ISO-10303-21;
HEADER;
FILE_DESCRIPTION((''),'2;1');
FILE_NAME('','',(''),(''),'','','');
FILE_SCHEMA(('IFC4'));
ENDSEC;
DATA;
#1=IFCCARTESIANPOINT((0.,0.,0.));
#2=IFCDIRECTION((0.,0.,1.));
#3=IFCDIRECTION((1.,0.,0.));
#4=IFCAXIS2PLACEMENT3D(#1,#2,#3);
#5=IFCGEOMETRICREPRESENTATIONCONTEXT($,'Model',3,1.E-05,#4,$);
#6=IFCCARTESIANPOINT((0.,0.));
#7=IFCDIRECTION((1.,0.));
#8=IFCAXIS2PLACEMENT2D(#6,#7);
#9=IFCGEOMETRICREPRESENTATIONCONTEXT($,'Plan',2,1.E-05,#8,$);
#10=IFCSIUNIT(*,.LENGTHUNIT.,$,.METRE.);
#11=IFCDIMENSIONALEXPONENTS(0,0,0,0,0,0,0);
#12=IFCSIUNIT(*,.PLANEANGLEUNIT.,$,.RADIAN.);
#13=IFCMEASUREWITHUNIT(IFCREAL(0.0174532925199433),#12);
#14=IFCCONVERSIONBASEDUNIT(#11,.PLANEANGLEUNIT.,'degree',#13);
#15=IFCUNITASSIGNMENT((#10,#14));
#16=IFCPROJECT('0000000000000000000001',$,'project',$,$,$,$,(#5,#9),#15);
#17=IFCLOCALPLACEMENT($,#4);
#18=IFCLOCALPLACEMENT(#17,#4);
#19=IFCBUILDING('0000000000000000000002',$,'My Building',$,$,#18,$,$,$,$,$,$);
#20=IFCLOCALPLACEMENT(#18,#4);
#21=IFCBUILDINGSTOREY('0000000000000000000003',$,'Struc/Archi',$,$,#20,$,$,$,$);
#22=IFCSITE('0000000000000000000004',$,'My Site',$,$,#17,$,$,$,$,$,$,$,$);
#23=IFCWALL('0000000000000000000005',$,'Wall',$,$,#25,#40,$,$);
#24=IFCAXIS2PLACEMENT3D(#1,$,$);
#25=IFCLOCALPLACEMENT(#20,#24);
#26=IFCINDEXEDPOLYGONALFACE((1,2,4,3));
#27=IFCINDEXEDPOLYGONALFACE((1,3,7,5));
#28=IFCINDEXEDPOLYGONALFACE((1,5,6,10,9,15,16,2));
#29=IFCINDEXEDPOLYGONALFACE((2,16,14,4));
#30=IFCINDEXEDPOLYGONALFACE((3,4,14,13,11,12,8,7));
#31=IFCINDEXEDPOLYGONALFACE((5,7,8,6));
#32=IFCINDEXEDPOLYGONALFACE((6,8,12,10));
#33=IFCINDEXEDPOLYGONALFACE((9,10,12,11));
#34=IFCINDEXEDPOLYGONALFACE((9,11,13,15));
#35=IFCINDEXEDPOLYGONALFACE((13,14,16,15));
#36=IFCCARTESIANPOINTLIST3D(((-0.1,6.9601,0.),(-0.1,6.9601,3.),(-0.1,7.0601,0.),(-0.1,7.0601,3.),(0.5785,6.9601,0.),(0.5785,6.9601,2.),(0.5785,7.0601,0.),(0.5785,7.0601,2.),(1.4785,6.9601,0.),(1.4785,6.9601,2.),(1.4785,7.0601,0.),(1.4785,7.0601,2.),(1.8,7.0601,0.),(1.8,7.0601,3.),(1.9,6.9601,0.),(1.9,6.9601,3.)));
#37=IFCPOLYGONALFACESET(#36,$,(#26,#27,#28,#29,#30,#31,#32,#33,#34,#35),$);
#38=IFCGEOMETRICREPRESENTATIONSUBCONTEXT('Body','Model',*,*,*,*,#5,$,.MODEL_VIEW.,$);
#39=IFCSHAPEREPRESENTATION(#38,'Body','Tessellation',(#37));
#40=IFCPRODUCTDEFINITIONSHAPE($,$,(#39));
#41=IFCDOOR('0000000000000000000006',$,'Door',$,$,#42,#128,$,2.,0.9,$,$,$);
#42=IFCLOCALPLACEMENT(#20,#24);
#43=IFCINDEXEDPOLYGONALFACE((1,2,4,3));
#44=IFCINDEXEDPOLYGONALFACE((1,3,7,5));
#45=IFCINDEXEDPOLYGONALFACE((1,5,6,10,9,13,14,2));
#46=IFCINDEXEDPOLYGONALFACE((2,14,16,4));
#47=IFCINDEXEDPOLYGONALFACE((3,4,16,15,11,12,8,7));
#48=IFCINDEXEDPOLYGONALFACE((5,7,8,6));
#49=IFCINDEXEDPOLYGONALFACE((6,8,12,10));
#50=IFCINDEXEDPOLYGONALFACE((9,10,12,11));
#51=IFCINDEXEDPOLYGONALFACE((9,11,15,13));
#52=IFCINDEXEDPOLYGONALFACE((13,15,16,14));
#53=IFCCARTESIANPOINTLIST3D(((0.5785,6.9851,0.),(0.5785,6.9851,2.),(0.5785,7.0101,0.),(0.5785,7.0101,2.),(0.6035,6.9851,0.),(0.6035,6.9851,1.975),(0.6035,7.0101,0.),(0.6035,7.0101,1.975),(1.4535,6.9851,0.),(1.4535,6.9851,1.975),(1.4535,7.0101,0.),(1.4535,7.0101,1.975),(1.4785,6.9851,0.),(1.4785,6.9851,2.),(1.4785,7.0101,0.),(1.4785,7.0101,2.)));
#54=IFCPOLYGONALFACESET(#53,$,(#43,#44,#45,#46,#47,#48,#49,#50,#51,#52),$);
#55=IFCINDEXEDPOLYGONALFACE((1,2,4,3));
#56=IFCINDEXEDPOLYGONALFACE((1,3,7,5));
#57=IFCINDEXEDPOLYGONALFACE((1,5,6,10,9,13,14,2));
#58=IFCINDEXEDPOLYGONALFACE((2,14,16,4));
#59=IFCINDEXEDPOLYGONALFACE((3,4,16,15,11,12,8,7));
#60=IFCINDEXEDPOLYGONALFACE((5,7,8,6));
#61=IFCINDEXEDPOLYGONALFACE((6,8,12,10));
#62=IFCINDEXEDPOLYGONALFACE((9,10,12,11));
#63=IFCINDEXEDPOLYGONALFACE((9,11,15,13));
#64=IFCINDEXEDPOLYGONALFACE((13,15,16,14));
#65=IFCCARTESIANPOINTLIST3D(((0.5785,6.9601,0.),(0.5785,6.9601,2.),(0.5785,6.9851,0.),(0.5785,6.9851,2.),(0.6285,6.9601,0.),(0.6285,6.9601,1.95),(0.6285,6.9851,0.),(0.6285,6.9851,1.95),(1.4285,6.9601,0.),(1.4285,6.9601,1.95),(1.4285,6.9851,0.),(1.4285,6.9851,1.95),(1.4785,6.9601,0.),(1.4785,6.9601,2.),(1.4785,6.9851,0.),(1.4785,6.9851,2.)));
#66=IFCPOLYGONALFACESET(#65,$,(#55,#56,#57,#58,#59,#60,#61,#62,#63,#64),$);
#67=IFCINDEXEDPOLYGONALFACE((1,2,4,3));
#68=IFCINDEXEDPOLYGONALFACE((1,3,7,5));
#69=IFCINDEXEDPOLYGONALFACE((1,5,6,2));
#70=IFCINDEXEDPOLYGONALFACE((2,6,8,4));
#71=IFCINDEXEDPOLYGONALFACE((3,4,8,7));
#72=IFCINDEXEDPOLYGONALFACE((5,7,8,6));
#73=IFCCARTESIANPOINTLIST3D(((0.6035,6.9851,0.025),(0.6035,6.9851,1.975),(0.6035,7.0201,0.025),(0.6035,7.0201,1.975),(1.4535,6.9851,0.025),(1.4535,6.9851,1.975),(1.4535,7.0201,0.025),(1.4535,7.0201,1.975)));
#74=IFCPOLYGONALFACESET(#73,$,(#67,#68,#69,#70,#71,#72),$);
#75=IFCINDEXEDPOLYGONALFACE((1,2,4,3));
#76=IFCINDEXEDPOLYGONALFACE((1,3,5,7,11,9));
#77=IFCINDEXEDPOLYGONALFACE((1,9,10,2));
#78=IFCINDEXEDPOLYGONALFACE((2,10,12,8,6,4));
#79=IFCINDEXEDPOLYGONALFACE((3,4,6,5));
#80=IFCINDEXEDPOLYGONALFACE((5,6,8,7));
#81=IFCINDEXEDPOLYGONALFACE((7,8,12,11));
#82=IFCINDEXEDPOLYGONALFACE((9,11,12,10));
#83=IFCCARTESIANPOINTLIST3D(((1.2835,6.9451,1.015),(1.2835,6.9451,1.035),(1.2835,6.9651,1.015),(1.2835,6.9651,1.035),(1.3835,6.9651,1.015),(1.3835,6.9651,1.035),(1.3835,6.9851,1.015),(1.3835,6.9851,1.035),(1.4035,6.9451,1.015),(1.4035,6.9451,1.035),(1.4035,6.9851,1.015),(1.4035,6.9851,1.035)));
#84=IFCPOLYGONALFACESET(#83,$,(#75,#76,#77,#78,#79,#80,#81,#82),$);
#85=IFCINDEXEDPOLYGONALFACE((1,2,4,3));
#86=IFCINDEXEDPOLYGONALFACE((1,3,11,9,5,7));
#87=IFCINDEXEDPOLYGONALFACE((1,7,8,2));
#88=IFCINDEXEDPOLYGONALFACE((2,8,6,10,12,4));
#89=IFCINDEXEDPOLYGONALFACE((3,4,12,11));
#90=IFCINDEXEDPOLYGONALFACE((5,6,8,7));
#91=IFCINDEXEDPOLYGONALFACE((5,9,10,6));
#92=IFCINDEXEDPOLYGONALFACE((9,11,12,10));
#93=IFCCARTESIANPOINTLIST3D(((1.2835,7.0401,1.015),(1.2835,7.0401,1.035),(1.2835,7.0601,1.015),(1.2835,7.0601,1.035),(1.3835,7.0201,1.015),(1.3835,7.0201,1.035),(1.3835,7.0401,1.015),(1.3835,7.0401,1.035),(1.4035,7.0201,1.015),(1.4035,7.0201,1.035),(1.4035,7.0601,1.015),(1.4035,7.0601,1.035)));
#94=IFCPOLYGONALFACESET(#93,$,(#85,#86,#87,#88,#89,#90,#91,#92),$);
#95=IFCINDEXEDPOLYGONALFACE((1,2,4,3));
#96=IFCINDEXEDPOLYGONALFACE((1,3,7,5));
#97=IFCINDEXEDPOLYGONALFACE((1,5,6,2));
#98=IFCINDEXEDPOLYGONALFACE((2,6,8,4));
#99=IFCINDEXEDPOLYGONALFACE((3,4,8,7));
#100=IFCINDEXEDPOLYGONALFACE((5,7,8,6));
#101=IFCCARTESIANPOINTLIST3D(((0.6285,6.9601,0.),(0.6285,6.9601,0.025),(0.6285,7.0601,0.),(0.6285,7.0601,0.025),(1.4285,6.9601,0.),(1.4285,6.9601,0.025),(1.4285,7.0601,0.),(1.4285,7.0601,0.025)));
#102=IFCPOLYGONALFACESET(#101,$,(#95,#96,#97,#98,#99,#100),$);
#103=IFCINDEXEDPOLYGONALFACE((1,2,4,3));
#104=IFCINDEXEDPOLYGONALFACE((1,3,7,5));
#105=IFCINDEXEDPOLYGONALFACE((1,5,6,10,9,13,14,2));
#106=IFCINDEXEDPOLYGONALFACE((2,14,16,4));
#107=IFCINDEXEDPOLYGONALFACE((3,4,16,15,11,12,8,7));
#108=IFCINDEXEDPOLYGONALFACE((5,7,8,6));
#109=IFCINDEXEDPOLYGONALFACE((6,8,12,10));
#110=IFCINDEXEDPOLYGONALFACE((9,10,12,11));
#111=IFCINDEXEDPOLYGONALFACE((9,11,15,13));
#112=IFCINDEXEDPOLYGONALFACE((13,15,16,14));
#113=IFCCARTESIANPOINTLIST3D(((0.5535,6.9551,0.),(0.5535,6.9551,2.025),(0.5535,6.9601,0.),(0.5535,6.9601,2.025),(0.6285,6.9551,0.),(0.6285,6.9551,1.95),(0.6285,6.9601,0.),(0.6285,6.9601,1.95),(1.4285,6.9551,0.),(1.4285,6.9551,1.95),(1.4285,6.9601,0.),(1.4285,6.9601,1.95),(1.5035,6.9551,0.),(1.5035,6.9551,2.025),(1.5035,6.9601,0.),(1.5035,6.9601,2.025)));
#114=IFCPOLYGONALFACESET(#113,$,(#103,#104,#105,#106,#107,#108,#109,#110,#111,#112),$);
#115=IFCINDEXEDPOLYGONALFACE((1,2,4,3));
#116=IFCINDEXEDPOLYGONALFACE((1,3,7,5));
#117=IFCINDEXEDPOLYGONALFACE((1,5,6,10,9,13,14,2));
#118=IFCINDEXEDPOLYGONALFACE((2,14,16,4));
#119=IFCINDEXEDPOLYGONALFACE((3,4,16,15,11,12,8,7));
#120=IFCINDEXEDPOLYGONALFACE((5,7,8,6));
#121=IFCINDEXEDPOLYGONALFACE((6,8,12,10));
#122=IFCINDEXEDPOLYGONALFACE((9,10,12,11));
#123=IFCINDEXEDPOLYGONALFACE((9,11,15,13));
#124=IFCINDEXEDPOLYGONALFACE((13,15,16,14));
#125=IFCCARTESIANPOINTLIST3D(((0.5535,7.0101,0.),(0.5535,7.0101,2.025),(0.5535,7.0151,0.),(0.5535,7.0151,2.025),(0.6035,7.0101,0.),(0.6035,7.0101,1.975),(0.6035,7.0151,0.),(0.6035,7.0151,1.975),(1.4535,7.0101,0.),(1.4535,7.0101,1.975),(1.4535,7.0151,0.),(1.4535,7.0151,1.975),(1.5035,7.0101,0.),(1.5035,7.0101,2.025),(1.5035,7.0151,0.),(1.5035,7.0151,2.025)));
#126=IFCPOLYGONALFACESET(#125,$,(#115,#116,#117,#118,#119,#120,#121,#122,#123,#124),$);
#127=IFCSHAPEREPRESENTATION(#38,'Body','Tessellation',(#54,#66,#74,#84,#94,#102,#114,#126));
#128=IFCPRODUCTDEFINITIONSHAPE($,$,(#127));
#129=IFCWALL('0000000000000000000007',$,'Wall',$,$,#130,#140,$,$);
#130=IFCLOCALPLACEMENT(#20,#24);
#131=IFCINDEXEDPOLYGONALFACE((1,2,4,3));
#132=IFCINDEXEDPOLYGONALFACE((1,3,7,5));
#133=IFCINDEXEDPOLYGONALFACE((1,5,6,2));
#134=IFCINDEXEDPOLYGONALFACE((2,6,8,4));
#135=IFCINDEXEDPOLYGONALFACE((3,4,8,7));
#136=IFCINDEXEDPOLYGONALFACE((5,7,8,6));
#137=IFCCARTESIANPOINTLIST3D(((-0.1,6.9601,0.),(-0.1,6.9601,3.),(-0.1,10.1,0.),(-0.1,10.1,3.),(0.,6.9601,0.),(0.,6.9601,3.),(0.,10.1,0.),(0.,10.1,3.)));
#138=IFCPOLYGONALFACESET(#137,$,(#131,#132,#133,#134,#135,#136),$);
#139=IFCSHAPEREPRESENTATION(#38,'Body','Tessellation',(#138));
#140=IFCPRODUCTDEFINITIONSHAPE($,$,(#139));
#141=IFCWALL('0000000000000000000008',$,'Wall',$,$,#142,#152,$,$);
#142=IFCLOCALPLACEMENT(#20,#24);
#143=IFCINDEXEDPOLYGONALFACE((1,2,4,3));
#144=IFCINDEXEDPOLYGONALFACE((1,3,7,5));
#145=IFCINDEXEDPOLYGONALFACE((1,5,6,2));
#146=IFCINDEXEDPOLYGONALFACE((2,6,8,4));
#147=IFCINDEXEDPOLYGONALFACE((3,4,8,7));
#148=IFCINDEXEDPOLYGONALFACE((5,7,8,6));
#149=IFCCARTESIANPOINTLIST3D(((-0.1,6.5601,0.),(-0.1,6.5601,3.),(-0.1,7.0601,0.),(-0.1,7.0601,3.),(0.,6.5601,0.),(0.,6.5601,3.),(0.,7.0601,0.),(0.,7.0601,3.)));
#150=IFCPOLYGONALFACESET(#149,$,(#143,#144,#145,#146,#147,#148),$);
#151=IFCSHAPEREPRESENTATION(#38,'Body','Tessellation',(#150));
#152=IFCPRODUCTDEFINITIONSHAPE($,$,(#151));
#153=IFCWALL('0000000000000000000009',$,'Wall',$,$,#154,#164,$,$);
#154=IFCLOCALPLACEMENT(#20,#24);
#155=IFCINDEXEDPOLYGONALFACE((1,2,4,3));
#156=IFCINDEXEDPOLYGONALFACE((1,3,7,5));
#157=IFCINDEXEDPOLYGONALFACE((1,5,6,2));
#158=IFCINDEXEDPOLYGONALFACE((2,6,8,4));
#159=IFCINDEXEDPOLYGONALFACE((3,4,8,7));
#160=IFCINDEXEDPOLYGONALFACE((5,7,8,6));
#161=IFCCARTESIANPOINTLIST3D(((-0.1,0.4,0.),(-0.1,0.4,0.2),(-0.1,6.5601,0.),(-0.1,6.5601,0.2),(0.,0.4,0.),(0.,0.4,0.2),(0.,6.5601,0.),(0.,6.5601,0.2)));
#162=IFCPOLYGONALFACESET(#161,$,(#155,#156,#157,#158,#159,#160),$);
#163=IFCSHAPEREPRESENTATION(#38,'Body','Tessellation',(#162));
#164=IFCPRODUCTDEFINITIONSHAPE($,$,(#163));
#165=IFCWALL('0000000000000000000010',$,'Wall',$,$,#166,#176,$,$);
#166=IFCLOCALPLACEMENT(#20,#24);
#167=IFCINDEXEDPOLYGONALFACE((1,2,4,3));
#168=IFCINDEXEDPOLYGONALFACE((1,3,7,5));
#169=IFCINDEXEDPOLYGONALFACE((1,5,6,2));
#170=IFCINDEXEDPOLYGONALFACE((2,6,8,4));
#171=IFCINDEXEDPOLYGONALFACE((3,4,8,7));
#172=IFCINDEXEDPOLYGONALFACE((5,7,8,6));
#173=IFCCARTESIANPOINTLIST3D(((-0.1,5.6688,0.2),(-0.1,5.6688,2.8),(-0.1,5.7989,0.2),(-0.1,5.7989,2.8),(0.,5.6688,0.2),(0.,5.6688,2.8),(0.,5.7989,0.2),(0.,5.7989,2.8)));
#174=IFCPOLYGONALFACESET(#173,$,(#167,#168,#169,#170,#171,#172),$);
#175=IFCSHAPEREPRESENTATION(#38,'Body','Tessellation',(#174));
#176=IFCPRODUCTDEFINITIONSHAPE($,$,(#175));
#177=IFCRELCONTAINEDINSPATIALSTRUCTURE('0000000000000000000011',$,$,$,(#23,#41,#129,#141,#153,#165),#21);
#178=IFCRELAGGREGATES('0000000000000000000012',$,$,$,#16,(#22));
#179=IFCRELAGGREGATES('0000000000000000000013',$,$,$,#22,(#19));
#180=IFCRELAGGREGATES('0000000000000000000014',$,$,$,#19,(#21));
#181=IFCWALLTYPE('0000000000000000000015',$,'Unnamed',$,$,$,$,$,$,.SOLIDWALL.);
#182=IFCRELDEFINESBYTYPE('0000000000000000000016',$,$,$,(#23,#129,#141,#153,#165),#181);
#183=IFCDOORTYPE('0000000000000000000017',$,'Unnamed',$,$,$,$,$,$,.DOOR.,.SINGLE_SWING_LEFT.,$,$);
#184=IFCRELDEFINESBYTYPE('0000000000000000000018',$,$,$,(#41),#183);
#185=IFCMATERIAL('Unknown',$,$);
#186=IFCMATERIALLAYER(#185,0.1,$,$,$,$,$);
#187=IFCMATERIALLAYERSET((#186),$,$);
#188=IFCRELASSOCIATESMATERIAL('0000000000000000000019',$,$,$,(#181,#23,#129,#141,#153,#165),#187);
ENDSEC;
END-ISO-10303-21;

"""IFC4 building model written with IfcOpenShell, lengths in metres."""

from ifc_helpers import new_model, entity, si_unit, converted_unit, frame, origin_with_axes, origin_2d_with_axis, place, context, subcontext, project, spatial, line, indexed_curve, outline, extrude, shape, source, transform, mapped, material, layer, layer_set, layer_usage, type_object, type_shapes, element, fill, save


model = new_model("IFC4")

# Units and contexts
model_context = context("Model", 3, precision=1e-05, world=origin_with_axes())
plan_context = context("Plan", 2, precision=1e-05, world=origin_2d_with_axis())
body_context_1 = subcontext(model_context, "Body", "Model", "MODEL_VIEW")
body_context_2 = subcontext(plan_context, "Body", "Plan", "PLAN_VIEW")
ifc_project = project(units=[si_unit("LENGTHUNIT", "METRE"), converted_unit("PLANEANGLEUNIT", "degree", entity("IfcReal", 0.0174532925199433), si_unit("PLANEANGLEUNIT", "RADIAN"), dimensions=[0, 0, 0, 0, 0, 0, 0])], contexts=[model_context, plan_context])

# Site, building, storey
site_placement = place(None, origin_with_axes())
site = spatial("IfcSite", under=ifc_project, at=site_placement, Name="My Site")
building_placement = place(site_placement, origin_with_axes())
building = spatial("IfcBuilding", under=site, at=building_placement, Name="My Building")
storey_placement = place(building_placement, origin_with_axes())
storey = spatial("IfcBuildingStorey", under=building, at=storey_placement, Name="Struc/Archi")

# Shared definitions
ifc_material = material(Name="Unknown")

# Wall, opening, door
ifc_layer_1 = layer(ifc_material, 0.1)
ifc_layer_set_1 = layer_set([ifc_layer_1])
wall_type = type_object("IfcWallType", Name="Unnamed", PredefinedType="SOLIDWALL", material=ifc_layer_set_1)
shared_shape_1 = source(origin_with_axes(), body_context_1, "Body", "SweptSolid", [
    extrude(outline(indexed_curve([(0.0, 0.0), (0.9, 0.0), (0.9, 2.0), (0.0, 2.0)], segments=[line(1, 2, 3, 4, 1)])), frame((0.0, -0.6, 0.0), z_axis=(0.0, -1.0, 0.0), x_axis=(1.0, 0.0, 0.0)), (0.0, 0.0, -1.0), 1.2),
])
door_type = type_object("IfcDoorType", Name="Unnamed", OperationType="SINGLE_SWING_LEFT", PredefinedType="DOOR")
shared_shape_2 = source(origin_with_axes(), body_context_1, "Body", "SweptSolid", [
    extrude(outline(indexed_curve([(0.0, 0.0), (0.0, 2.0), (0.9, 2.0), (0.9, 0.0), (0.875, 0.0), (0.875, 1.975), (0.025, 1.975), (0.025, 0.0)], segments=[line(1, 2, 3, 4, 5, 6, 7, 8, 1)])), frame((0.0, 0.025, 0.0), z_axis=(0.0, -1.0, 0.0), x_axis=(1.0, 0.0, 0.0)), (0.0, 0.0, -1.0), 0.025),
    extrude(outline(indexed_curve([(0.0, 0.0), (0.0, 2.0), (0.9, 2.0), (0.9, 0.0), (0.85, 0.0), (0.85, 1.95), (0.05, 1.95), (0.05, 0.0)], segments=[line(1, 2, 3, 4, 5, 6, 7, 8, 1)])), frame((0.0, 0.0, 0.0), z_axis=(0.0, -1.0, 0.0), x_axis=(1.0, 0.0, 0.0)), (0.0, 0.0, -1.0), 0.025),
    extrude(outline(indexed_curve([(0.0, 0.0), (0.85, 0.0), (0.85, 0.035), (0.0, 0.035)], segments=[line(1, 2, 3, 4, 1)])), frame((0.025, 0.025, 0.025), z_axis=(0.0, 0.0, 1.0), x_axis=(1.0, 0.0, 0.0)), (0.0, 0.0, 1.0), 1.95),
    extrude(outline(indexed_curve([(0.0, 0.0), (0.0, -0.04), (-0.12, -0.04), (-0.12, -0.02), (-0.02, -0.02), (-0.02, 0.0)], segments=[line(1, 2, 3, 4, 5, 6, 1)])), frame((0.825, 0.025, 1.015), z_axis=(0.0, 0.0, 1.0), x_axis=(1.0, 0.0, 0.0)), (0.0, 0.0, 1.0), 0.02),
    extrude(outline(indexed_curve([(0.0, 0.0), (0.0, 0.04), (-0.12, 0.04), (-0.12, 0.02), (-0.02, 0.02), (-0.02, 0.0)], segments=[line(1, 2, 3, 4, 5, 6, 1)])), frame((0.825, 0.06, 1.015), z_axis=(0.0, 0.0, 1.0), x_axis=(1.0, 0.0, 0.0)), (0.0, 0.0, 1.0), 0.02),
    extrude(outline(indexed_curve([(0.0, 0.0), (0.8, 0.0), (0.8, 0.1), (0.0, 0.1)], segments=[line(1, 2, 3, 4, 1)])), frame((0.05, 0.0, 0.0), z_axis=(0.0, 0.0, 1.0), x_axis=(1.0, 0.0, 0.0)), (0.0, 0.0, 1.0), 0.025),
    extrude(outline(indexed_curve([(0.0, 0.0), (0.0, 2.025), (0.95, 2.025), (0.95, 0.0), (0.875, 0.0), (0.875, 1.95), (0.075, 1.95), (0.075, 0.0)], segments=[line(1, 2, 3, 4, 5, 6, 7, 8, 1)])), frame((-0.025, -0.005, 0.0), z_axis=(0.0, -1.0, 0.0), x_axis=(1.0, 0.0, 0.0)), (0.0, 0.0, -1.0), 0.005),
    extrude(outline(indexed_curve([(0.0, 0.0), (0.0, 2.025), (0.95, 2.025), (0.95, 0.0), (0.9, 0.0), (0.9, 1.975), (0.05, 1.975), (0.05, 0.0)], segments=[line(1, 2, 3, 4, 5, 6, 7, 8, 1)])), frame((-0.025, 0.05, 0.0), z_axis=(0.0, -1.0, 0.0), x_axis=(1.0, 0.0, 0.0)), (0.0, 0.0, -1.0), 0.005),
])
shared_shape_3 = source(origin_with_axes(), body_context_2, "Body", "Curve2D", [
    entity("IfcIndexedPolyCurve", entity("IfcCartesianPointList2D", [[0.0, 0.0], [0.0, 0.05], [0.025, 0.05], [0.025, 0.025], [0.05, 0.025], [0.05, 0.0]]), [entity("IfcLineIndex", [1, 2, 3, 4, 5, 6, 1])]),
    entity("IfcIndexedPolyCurve", entity("IfcCartesianPointList2D", [[0.9, 0.0], [0.9, 0.05], [0.875, 0.05], [0.875, 0.025], [0.85, 0.025], [0.85, 0.0]]), [entity("IfcLineIndex", [1, 2, 3, 4, 5, 6, 1])]),
    entity("IfcTrimmedCurve", entity("IfcEllipse", entity("IfcAxis2Placement2D", entity("IfcCartesianPoint", [0.06, 0.05]), entity("IfcDirection", [1.0, 0.0])), 0.815, 0.85), [entity("IfcCartesianPoint", [0.875, 0.05])], [entity("IfcCartesianPoint", [0.06, 0.9])], True, "CARTESIAN"),
    entity("IfcIndexedPolyCurve", entity("IfcCartesianPointList2D", [[0.025, 0.05], [0.06, 0.05], [0.06, 0.9], [0.025, 0.9]]), [entity("IfcLineIndex", [1, 2, 3, 4, 1])]),
])
type_shapes(door_type, [shared_shape_2, shared_shape_3])
ifc_layer_usage_1 = layer_usage(ifc_layer_set_1, "AXIS2", "POSITIVE", 0.0)
wall_1_placement = place(storey_placement, frame((-0.1, 6.9601, 0.0), z_axis=(0.0, 0.0, 1.0), x_axis=(1.0, 0.0, 0.0)))
wall_1 = element("IfcWall", 1, at=wall_1_placement, inside=storey, type_object=wall_type, material=ifc_layer_usage_1, Name="Wall", context=body_context_1, shape_type="SweptSolid", body=[
    extrude(outline(indexed_curve([(0.0, 0.0), (0.0, 0.1), (1.9, 0.1), (2.0, 0.0)], segments=[line(1, 2, 3, 4, 1)])), origin_with_axes(), (0.0, 0.0, 1.0), 3.0),
])
opening_1_placement = place(wall_1_placement, frame((0.6785, 0.0, 0.0), z_axis=(0.0, 0.0, 1.0), x_axis=(1.0, 0.0, 0.0)))
opening_1 = element("IfcOpeningElement", 2, at=opening_1_placement, cuts=wall_1, PredefinedType="OPENING", context=body_context_1, shape_type="MappedRepresentation", body=[
    mapped(shared_shape_1, transform((0.0, 0.0, 0.0), x_axis=(1.0, 0.0, 0.0), y_axis=(0.0, 1.0, 0.0), z_axis=(0.0, 0.0, 1.0), scale=1.0)),
])
door_1_placement = place(opening_1_placement, origin_with_axes())
door_1 = element("IfcDoor", 3, at=door_1_placement, inside=storey, type_object=door_type, Name="Door", OverallHeight=2.0, OverallWidth=0.9, shapes=[
    shape(body_context_1, "Body", "MappedRepresentation", [mapped(shared_shape_2, transform((0.0, 0.0, 0.0), x_axis=(1.0, 0.0, 0.0), y_axis=(0.0, 1.0, 0.0), z_axis=(0.0, 0.0, 1.0), scale=1.0))]),
    shape(body_context_2, "Body", "MappedRepresentation", [mapped(shared_shape_3, transform((0.0, 0.0, 0.0), x_axis=(1.0, 0.0, 0.0), y_axis=(0.0, 1.0, 0.0), z_axis=(0.0, 0.0, 1.0), scale=1.0))]),
])
fill(opening_1, door_1)

# Walls
ifc_layer_usage_2 = layer_usage(ifc_layer_set_1, "AXIS2", "POSITIVE", 0.0)
wall_2_placement = place(storey_placement, frame((-0.1, 10.1, 0.0), z_axis=(0.0, 0.0, 1.0), x_axis=(0.0, -1.0, 0.0)))
element("IfcWall", 4, at=wall_2_placement, inside=storey, type_object=wall_type, material=ifc_layer_usage_2, Name="Wall", context=body_context_1, shape_type="SweptSolid", body=[
    extrude(outline(indexed_curve([(0.0, 0.0), (0.0, 0.1), (3.1399, 0.1), (3.1399, 0.0)], segments=[line(1, 2, 3, 4, 1)])), origin_with_axes(), (0.0, 0.0, 1.0), 3.0),
])
ifc_layer_usage_3 = layer_usage(ifc_layer_set_1, "AXIS2", "POSITIVE", 0.0)
wall_3_placement = place(storey_placement, frame((-0.1, 7.0601, 0.0), z_axis=(0.0, 0.0, 1.0), x_axis=(0.0, -1.0, 0.0)))
element("IfcWall", 5, at=wall_3_placement, inside=storey, type_object=wall_type, material=ifc_layer_usage_3, Name="Wall", context=body_context_1, shape_type="SweptSolid", body=[
    extrude(outline(indexed_curve([(0.0, 0.0), (0.0, 0.1), (0.5, 0.1), (0.5, 0.0)], segments=[line(1, 2, 3, 4, 1)])), origin_with_axes(), (0.0, 0.0, 1.0), 3.0),
])
ifc_layer_usage_4 = layer_usage(ifc_layer_set_1, "AXIS2", "POSITIVE", 0.0)
wall_4_placement = place(storey_placement, frame((-0.1, 6.5601, 0.0), z_axis=(0.0, 0.0, 1.0), x_axis=(0.0, -1.0, 0.0)))
element("IfcWall", 6, at=wall_4_placement, inside=storey, type_object=wall_type, material=ifc_layer_usage_4, Name="Wall", context=body_context_1, shape_type="SweptSolid", body=[
    extrude(outline(indexed_curve([(0.0, 0.0), (0.0, 0.1), (6.1601, 0.1), (6.1601, 0.0)], segments=[line(1, 2, 3, 4, 1)])), origin_with_axes(), (0.0, 0.0, 1.0), 0.2),
])
ifc_layer_usage_5 = layer_usage(ifc_layer_set_1, "AXIS2", "POSITIVE", 0.0)
wall_5_placement = place(storey_placement, frame((-0.1, 5.7989, 0.2), z_axis=(0.0, 0.0, 1.0), x_axis=(0.0, -1.0, 0.0)))
element("IfcWall", 7, at=wall_5_placement, inside=storey, type_object=wall_type, material=ifc_layer_usage_5, Name="Wall", context=body_context_1, shape_type="SweptSolid", body=[
    extrude(outline(indexed_curve([(0.0, 0.0), (0.0, 0.1), (0.1301, 0.1), (0.1301, 0.0)], segments=[line(1, 2, 3, 4, 1)])), origin_with_axes(), (0.0, 0.0, 1.0), 2.6),
])

save(model, "model.ifc")
